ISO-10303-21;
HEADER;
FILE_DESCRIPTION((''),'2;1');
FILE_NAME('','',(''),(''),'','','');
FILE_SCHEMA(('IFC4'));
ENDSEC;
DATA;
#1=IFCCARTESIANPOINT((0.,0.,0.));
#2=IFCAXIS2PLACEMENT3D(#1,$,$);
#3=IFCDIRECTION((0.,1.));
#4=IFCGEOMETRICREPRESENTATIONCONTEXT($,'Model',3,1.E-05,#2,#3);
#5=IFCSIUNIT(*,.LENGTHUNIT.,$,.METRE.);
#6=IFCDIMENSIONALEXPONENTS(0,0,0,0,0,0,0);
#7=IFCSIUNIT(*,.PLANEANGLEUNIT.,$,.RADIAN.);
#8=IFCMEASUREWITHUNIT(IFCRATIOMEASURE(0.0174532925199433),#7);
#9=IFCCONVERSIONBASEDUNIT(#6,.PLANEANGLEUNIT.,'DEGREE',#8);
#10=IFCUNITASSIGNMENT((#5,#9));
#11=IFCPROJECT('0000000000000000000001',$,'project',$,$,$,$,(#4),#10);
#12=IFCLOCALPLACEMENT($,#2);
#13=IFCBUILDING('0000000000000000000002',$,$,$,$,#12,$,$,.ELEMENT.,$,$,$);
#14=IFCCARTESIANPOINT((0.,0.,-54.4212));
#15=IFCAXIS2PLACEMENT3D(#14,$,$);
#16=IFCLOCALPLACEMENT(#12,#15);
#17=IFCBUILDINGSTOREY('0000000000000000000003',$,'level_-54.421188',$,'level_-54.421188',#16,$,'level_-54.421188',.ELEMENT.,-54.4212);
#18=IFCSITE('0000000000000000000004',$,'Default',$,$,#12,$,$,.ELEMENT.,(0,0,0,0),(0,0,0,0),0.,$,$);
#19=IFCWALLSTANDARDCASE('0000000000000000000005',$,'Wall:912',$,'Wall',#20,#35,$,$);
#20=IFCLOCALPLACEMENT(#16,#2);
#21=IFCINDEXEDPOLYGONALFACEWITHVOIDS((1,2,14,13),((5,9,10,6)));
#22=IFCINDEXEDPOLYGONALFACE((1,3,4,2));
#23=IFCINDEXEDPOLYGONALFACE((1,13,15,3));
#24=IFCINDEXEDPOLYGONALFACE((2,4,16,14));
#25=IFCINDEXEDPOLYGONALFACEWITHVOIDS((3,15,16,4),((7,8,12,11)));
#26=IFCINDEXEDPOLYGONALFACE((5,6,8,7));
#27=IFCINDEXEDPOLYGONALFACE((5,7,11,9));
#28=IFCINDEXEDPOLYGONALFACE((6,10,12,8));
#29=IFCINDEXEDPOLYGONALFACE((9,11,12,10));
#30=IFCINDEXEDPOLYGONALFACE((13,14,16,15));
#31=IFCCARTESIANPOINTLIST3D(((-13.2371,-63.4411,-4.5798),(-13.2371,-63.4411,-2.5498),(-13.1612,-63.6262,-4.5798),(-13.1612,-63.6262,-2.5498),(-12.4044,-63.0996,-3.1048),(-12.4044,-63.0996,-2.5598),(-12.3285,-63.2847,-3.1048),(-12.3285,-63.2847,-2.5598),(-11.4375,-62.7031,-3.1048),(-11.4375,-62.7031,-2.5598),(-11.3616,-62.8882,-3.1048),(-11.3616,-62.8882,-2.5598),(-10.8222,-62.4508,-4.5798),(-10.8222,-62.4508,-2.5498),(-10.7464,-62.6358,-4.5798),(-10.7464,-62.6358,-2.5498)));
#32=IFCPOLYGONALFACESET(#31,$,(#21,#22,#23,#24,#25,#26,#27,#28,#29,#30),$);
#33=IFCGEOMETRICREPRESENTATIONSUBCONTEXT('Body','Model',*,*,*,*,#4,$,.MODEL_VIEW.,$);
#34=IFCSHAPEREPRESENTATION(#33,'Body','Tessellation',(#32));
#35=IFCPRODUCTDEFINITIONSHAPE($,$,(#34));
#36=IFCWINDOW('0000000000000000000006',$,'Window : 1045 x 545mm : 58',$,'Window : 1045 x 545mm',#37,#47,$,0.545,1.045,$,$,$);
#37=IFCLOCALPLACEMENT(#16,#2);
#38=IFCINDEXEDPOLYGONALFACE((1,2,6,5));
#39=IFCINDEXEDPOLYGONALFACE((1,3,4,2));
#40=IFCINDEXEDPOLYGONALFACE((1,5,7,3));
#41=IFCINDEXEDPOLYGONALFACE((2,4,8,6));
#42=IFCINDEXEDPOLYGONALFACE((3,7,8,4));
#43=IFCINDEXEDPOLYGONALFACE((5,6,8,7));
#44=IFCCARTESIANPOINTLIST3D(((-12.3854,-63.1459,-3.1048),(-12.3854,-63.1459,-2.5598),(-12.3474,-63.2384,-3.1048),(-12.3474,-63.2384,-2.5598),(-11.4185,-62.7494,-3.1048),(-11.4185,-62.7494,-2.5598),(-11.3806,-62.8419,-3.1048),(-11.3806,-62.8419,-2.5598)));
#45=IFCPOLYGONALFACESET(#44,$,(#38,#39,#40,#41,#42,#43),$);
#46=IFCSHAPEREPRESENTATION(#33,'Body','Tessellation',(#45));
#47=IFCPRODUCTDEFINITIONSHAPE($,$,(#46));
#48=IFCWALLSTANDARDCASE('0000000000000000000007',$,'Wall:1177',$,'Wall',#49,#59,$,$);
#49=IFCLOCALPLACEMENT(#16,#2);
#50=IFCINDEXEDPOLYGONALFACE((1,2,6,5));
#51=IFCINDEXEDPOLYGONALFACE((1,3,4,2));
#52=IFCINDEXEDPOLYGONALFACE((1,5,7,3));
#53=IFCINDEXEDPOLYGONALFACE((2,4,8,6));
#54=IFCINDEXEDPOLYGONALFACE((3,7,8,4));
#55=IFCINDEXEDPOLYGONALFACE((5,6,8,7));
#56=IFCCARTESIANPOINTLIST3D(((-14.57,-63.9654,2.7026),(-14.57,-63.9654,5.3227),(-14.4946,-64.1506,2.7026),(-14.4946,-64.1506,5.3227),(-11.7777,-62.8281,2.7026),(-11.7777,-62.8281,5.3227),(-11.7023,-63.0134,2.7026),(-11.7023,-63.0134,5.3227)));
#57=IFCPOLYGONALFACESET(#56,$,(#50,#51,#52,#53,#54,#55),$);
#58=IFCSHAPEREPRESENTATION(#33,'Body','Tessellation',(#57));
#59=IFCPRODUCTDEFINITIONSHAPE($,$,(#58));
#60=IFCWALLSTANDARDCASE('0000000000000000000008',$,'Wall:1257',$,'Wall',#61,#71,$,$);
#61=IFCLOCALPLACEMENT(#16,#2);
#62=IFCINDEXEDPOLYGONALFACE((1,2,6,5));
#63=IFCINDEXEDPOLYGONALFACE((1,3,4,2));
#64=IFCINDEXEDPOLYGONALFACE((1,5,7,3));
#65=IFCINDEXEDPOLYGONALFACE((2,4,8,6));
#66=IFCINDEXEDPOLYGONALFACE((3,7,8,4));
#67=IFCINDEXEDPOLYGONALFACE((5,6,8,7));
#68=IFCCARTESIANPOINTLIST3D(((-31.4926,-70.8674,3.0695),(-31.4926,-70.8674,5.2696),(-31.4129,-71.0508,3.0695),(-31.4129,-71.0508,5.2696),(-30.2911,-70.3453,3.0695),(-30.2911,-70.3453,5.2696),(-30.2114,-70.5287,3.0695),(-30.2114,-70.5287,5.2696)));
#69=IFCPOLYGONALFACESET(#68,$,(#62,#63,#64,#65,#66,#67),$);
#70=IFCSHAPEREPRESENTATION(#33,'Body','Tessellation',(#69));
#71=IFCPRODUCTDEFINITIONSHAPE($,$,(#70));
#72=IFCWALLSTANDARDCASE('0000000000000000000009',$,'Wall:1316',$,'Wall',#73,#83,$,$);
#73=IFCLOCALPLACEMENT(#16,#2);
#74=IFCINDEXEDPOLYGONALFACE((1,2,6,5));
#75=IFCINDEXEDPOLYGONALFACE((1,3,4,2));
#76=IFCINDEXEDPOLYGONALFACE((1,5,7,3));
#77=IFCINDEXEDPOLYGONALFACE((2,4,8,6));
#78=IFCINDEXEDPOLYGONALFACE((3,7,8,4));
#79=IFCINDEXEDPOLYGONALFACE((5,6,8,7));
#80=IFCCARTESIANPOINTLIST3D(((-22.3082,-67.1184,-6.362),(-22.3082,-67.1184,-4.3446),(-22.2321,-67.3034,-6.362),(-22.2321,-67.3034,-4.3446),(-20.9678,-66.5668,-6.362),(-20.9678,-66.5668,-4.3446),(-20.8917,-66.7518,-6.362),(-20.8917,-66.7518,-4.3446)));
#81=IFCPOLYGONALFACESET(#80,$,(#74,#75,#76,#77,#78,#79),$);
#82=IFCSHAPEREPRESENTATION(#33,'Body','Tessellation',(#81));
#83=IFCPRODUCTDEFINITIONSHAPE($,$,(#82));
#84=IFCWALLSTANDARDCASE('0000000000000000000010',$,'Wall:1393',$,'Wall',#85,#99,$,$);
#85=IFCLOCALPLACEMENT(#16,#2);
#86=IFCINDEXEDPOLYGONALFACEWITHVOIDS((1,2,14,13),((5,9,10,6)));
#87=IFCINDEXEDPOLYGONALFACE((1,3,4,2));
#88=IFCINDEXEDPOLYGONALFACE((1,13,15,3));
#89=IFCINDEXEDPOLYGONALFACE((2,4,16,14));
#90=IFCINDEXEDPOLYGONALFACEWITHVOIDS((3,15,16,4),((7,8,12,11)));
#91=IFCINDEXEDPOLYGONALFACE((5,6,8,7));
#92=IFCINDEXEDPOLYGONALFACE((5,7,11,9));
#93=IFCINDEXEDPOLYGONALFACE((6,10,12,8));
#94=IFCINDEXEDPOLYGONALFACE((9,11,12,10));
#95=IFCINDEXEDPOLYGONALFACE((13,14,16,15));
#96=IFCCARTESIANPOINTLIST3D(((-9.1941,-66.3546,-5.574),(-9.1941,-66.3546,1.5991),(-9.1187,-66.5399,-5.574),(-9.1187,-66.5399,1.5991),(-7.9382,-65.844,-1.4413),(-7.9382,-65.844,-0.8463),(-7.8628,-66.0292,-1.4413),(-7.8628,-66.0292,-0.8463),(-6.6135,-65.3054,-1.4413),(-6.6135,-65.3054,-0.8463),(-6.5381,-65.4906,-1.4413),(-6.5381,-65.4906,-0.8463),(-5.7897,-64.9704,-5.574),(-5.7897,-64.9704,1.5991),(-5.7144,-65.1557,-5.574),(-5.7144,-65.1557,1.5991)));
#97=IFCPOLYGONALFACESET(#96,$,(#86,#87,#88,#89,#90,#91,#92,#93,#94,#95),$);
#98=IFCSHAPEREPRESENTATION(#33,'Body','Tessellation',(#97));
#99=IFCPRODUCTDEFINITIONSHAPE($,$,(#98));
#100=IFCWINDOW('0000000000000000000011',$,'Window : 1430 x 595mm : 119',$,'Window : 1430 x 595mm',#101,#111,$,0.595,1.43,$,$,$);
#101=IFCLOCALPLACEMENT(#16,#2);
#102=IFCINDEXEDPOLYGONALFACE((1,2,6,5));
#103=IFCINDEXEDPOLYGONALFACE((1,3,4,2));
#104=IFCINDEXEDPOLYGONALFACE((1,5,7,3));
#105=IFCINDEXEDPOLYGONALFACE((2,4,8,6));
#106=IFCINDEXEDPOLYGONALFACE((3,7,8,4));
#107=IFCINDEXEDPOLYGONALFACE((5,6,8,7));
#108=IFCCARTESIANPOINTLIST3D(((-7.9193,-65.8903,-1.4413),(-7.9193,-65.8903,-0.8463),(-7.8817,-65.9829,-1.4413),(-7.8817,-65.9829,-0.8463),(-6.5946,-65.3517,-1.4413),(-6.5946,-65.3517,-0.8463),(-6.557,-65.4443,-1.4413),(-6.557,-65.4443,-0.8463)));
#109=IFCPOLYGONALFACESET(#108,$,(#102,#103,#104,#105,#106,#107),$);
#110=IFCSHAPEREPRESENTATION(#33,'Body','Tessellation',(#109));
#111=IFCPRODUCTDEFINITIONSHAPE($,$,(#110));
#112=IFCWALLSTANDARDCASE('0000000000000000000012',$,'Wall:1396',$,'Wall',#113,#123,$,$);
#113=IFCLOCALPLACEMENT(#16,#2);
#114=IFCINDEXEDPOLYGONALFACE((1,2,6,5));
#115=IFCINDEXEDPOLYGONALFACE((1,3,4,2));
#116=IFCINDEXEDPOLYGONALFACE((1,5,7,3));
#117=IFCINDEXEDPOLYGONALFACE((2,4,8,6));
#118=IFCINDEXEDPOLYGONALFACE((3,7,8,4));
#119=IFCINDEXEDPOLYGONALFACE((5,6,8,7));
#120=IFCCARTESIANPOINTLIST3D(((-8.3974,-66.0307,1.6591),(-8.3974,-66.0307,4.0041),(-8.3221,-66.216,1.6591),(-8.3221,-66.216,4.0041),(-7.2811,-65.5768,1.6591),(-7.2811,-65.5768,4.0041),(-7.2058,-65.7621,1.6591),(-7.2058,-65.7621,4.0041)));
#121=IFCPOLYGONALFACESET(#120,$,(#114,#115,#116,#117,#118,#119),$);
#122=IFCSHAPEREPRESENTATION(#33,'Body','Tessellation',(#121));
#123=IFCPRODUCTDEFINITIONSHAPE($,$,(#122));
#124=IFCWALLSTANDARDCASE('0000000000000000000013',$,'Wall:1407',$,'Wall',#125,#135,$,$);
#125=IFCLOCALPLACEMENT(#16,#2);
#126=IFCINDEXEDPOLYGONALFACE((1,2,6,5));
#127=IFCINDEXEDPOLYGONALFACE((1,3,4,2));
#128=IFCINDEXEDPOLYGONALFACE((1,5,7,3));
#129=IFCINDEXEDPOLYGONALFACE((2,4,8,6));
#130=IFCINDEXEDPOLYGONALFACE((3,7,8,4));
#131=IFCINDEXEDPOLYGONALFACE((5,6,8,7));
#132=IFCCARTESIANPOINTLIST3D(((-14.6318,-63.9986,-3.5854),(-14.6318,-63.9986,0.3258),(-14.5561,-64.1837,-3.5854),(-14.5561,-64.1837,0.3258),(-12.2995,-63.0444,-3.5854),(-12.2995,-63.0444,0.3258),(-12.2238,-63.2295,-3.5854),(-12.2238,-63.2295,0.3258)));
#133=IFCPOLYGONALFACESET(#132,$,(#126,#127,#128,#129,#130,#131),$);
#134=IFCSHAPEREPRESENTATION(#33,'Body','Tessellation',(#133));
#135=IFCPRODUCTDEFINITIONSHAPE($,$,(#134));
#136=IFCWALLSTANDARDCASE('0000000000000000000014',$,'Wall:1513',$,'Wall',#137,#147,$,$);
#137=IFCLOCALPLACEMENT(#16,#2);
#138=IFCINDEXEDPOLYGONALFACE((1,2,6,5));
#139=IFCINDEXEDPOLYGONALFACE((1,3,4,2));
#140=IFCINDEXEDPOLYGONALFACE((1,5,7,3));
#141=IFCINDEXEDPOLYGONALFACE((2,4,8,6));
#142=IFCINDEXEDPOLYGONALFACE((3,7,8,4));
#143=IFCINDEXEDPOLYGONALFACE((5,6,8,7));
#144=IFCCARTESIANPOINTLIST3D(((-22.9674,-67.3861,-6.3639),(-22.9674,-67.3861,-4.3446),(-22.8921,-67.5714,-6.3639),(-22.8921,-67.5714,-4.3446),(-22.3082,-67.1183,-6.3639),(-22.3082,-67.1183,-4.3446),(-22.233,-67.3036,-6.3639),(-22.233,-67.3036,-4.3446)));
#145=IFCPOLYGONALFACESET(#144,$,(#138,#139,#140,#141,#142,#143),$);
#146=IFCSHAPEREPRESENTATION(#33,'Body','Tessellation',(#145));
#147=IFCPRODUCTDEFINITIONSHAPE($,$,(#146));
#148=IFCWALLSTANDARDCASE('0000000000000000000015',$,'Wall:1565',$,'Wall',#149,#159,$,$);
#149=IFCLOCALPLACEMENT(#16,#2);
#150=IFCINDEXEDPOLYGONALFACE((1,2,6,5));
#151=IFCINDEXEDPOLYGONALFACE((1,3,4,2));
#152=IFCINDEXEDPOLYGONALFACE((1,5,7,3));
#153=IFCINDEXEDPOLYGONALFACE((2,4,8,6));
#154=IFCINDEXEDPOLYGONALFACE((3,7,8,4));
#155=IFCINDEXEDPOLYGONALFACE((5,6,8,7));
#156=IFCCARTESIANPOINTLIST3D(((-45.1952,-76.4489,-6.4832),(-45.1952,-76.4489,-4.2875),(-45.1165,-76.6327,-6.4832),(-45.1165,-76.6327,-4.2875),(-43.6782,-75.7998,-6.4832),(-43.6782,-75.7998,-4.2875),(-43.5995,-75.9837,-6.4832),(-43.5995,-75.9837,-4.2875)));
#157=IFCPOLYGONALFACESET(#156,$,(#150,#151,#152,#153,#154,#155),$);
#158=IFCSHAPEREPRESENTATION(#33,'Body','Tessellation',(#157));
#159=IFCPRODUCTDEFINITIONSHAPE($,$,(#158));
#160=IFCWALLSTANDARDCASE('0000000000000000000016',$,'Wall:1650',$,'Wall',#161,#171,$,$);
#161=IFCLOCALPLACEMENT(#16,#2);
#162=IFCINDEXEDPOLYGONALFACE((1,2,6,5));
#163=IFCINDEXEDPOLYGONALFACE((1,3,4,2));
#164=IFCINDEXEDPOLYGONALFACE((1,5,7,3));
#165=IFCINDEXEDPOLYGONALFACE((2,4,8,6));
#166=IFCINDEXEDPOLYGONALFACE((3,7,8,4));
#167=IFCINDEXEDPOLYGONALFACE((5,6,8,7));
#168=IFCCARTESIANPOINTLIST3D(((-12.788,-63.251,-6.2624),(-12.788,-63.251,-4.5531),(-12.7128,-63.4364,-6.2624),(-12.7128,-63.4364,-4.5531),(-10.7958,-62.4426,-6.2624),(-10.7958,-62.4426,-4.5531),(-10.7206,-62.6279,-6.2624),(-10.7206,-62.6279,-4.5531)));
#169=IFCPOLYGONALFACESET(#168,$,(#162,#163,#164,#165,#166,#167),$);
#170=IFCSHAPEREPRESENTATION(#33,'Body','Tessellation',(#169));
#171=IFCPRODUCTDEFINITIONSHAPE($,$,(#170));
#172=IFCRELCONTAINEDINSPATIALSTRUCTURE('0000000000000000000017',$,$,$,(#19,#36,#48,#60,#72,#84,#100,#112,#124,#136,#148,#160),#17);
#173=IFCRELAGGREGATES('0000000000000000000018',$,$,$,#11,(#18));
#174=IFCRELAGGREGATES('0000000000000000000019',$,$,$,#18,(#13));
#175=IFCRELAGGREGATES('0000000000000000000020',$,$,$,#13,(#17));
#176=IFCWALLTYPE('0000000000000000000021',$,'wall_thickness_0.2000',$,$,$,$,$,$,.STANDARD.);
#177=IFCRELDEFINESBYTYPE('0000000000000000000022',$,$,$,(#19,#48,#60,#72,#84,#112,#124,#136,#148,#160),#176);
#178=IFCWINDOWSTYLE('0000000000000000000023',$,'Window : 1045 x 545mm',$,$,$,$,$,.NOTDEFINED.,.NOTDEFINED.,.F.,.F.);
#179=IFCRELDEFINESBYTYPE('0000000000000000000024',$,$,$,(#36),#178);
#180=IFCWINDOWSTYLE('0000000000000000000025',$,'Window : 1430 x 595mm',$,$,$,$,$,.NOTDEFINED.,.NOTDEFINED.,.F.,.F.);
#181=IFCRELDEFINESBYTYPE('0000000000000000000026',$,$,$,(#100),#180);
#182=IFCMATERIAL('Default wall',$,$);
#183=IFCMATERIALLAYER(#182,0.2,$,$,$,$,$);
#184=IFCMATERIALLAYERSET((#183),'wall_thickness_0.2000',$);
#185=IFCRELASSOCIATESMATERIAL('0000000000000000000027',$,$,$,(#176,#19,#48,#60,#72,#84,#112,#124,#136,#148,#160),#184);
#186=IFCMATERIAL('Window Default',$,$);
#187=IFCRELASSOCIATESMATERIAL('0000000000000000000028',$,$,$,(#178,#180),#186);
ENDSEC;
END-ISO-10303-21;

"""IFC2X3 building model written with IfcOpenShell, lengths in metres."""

from ifc_helpers import new_model, entity, si_unit, converted_unit, direction, frame, frame_2d, origin, origin_2d_with_axis, place, context, subcontext, project, spatial, polyline, rectangle, outline, extrude, source, transform, mapped, material, layer, layer_set, layer_usage, type_object, type_shapes, element, fill, save


model = new_model("IFC2X3")

# Units and contexts
model_context = context("Model", 3, precision=1e-05, world=origin(), true_north=direction((0.0, 1.0)))
body_context = subcontext(model_context, "Body", "Model", "MODEL_VIEW")
ifc_project = project(units=[si_unit("LENGTHUNIT", "METRE"), converted_unit("PLANEANGLEUNIT", "DEGREE", entity("IfcRatioMeasure", 0.0174532925199433), si_unit("PLANEANGLEUNIT", "RADIAN"), dimensions=[0, 0, 0, 0, 0, 0, 0])], contexts=[model_context])

# Site, building, storey
placement_1 = place(None, origin())
site = spatial("IfcSite", under=ifc_project, at=placement_1, Name="Default", CompositionType="ELEMENT", RefLatitude=(0, 0, 0, 0), RefLongitude=(0, 0, 0, 0), RefElevation=0.0)
building = spatial("IfcBuilding", under=site, at=placement_1, CompositionType="ELEMENT")
storey_placement = place(placement_1, frame((0.0, 0.0, -54.4212)))
storey = spatial("IfcBuildingStorey", under=building, at=storey_placement, Name="level_-54.421188", ObjectType="level_-54.421188", LongName="level_-54.421188", CompositionType="ELEMENT", Elevation=-54.4212)

# Shared definitions
ifc_material_1 = material(Name="Default wall")
ifc_layer = layer(ifc_material_1, 0.2)
ifc_layer_set = layer_set([ifc_layer], Name="wall_thickness_0.2000")
ifc_layer_usage = layer_usage(ifc_layer_set, "AXIS2", "POSITIVE", -0.1)
wall_type = type_object("IfcWallType", Name="wall_thickness_0.2000", PredefinedType="STANDARD", material=ifc_layer_set)

# Wall, opening, window
placement_2 = place(placement_1, frame((0.0, 0.0, -59.001)))
wall_1_placement = place(placement_2, frame((-13.1991, -63.5337, 0.0), z_axis=(0.0, 0.0, 1.0), x_axis=(0.925216, 0.379441, 0.0)))
wall_1 = element("IfcWallStandardCase", 1, at=wall_1_placement, inside=storey, type_object=wall_type, material=ifc_layer_usage, Name="Wall:912", ObjectType="Wall", context=body_context, shape_type="SweptSolid", body=[
    extrude(outline(polyline([(2.61, -0.1), (2.61, 0.1), (0.0, 0.1), (0.0, -0.1), (2.61, -0.1)])), origin(), (0.0, 0.0, 1.0), 2.03),
])
opening_1_placement = place(wall_1_placement, frame((0.9, -0.1, 1.475)))
opening_1 = element("IfcOpeningElement", 2, at=opening_1_placement, cuts=wall_1, ObjectType="Opening", context=body_context, shape_type="SweptSolid", body=[
    extrude(rectangle(XDim=1.045, YDim=0.545, at=frame_2d((0.2725, 0.5225), x_axis=(0.0, 1.0))), frame((0.0, 0.0, 0.0), z_axis=(0.0, 1.0, 0.0), x_axis=(0.0, 0.0, 1.0)), (0.0, 0.0, 1.0), 0.2),
])
ifc_material_2 = material(Name="Window Default")
window_style_1 = type_object("IfcWindowStyle", Name="Window : 1045 x 545mm", ConstructionType="NOTDEFINED", OperationType="NOTDEFINED", ParameterTakesPrecedence=False, Sizeable=False, material=ifc_material_2)
shared_shape_1 = source(origin(), body_context, "Body", "SweptSolid", [
    extrude(rectangle(XDim=0.1, YDim=1.045, at=origin_2d_with_axis()), frame((0.5225, 0.1, 0.0), z_axis=(0.0, 0.0, 1.0), x_axis=(0.0, 1.0, 0.0)), (0.0, 0.0, 1.0), 0.545),
])
type_shapes(window_style_1, [shared_shape_1])
window_1_placement = place(opening_1_placement, origin())
window_1 = element("IfcWindow", 3, at=window_1_placement, inside=storey, type_object=window_style_1, Name="Window : 1045 x 545mm : 58", ObjectType="Window : 1045 x 545mm", OverallHeight=0.545, OverallWidth=1.045, context=body_context, shape_type="MappedRepresentation", body=[
    mapped(shared_shape_1, transform((0.0, 0.0, 0.0), scale=1.0)),
])
fill(opening_1, window_1)

# Walls
placement_3 = place(placement_1, frame((0.0, 0.0, -51.7186)))
wall_2_placement = place(placement_3, frame((-11.74, -62.9207, 0.0), z_axis=(0.0, 0.0, 1.0), x_axis=(-0.926134, -0.377196, 0.0)))
element("IfcWallStandardCase", 4, at=wall_2_placement, inside=storey, type_object=wall_type, material=ifc_layer_usage, Name="Wall:1177", ObjectType="Wall", context=body_context, shape_type="SweptSolid", body=[
    extrude(outline(polyline([(3.015, -0.1), (3.015, 0.1), (0.0, 0.1), (0.0, -0.1), (3.015, -0.1)])), origin(), (0.0, 0.0, 1.0), 2.6201),
])
placement_4 = place(placement_1, frame((0.0, 0.0, -51.3517)))
wall_3_placement = place(placement_4, frame((-30.2513, -70.437, 0.0), z_axis=(0.0, 0.0, 1.0), x_axis=(-0.917161, -0.398516, 0.0)))
element("IfcWallStandardCase", 5, at=wall_3_placement, inside=storey, type_object=wall_type, material=ifc_layer_usage, Name="Wall:1257", ObjectType="Wall", context=body_context, shape_type="SweptSolid", body=[
    extrude(outline(polyline([(1.31, -0.1), (1.31, 0.1), (0.0, 0.1), (0.0, -0.1), (1.31, -0.1)])), origin(), (0.0, 0.0, 1.0), 2.2001),
])
placement_5 = place(placement_1, frame((0.0, 0.0, -60.7832)))
wall_4_placement = place(placement_5, frame((-20.9298, -66.6593, 0.0), z_axis=(0.0, 0.0, 1.0), x_axis=(-0.924764, -0.380541, 0.0)))
element("IfcWallStandardCase", 6, at=wall_4_placement, inside=storey, type_object=wall_type, material=ifc_layer_usage, Name="Wall:1316", ObjectType="Wall", context=body_context, shape_type="SweptSolid", body=[
    extrude(outline(polyline([(1.4494, -0.1), (1.4494, 0.1), (0.0, 0.1), (0.0, -0.1), (1.4494, -0.1)])), origin(), (0.0, 0.0, 1.0), 2.0174),
])

# Wall, opening, window
placement_6 = place(placement_1, frame((0.0, 0.0, -59.9952)))
wall_5_placement = place(placement_6, frame((-5.752, -65.0631, 0.0), z_axis=(0.0, 0.0, 1.0), x_axis=(-0.926359, -0.376643, 0.0)))
wall_5 = element("IfcWallStandardCase", 7, at=wall_5_placement, inside=storey, type_object=wall_type, material=ifc_layer_usage, Name="Wall:1393", ObjectType="Wall", context=body_context, shape_type="SweptSolid", body=[
    extrude(outline(polyline([(3.675, -0.1), (3.675, 0.1), (0.0, 0.1), (0.0, -0.1), (3.675, -0.1)])), origin(), (0.0, 0.0, 1.0), 7.1731),
])
opening_2_placement = place(wall_5_placement, frame((0.8892, -0.1, 4.1327)))
opening_2 = element("IfcOpeningElement", 8, at=opening_2_placement, cuts=wall_5, ObjectType="Opening", context=body_context, shape_type="SweptSolid", body=[
    extrude(rectangle(XDim=1.43, YDim=0.595, at=frame_2d((0.2975, 0.715), x_axis=(0.0, 1.0))), frame((0.0, 0.0, 0.0), z_axis=(0.0, 1.0, 0.0), x_axis=(0.0, 0.0, 1.0)), (0.0, 0.0, 1.0), 0.2),
])
window_style_2 = type_object("IfcWindowStyle", Name="Window : 1430 x 595mm", ConstructionType="NOTDEFINED", OperationType="NOTDEFINED", ParameterTakesPrecedence=False, Sizeable=False, material=ifc_material_2)
shared_shape_2 = source(origin(), body_context, "Body", "SweptSolid", [
    extrude(rectangle(XDim=0.1, YDim=1.43, at=origin_2d_with_axis()), frame((0.715, 0.1, 0.0), z_axis=(0.0, 0.0, 1.0), x_axis=(0.0, 1.0, 0.0)), (0.0, 0.0, 1.0), 0.595),
])
type_shapes(window_style_2, [shared_shape_2])
window_2_placement = place(opening_2_placement, origin())
window_2 = element("IfcWindow", 9, at=window_2_placement, inside=storey, type_object=window_style_2, Name="Window : 1430 x 595mm : 119", ObjectType="Window : 1430 x 595mm", OverallHeight=0.595, OverallWidth=1.43, context=body_context, shape_type="MappedRepresentation", body=[
    mapped(shared_shape_2, transform((0.0, 0.0, 0.0), scale=1.0)),
])
fill(opening_2, window_2)

# Walls
placement_7 = place(placement_1, frame((0.0, 0.0, -52.7621)))
wall_6_placement = place(placement_7, frame((-7.2435, -65.6695, 0.0), z_axis=(0.0, 0.0, 1.0), x_axis=(-0.926358, -0.376645, 0.0)))
element("IfcWallStandardCase", 10, at=wall_6_placement, inside=storey, type_object=wall_type, material=ifc_layer_usage, Name="Wall:1396", ObjectType="Wall", context=body_context, shape_type="SweptSolid", body=[
    extrude(outline(polyline([(1.205, -0.1), (1.205, 0.1), (0.0, 0.1), (0.0, -0.1), (1.205, -0.1)])), origin(), (0.0, 0.0, 1.0), 2.345),
])
placement_8 = place(placement_1, frame((0.0, 0.0, -58.0066)))
wall_7_placement = place(placement_8, frame((-12.2616, -63.1369, 0.0), z_axis=(0.0, 0.0, 1.0), x_axis=(-0.925539, -0.378653, 0.0)))
element("IfcWallStandardCase", 11, at=wall_7_placement, inside=storey, type_object=wall_type, material=ifc_layer_usage, Name="Wall:1407", ObjectType="Wall", context=body_context, shape_type="SweptSolid", body=[
    extrude(outline(polyline([(2.52, -0.1), (2.52, 0.1), (0.0, 0.1), (0.0, -0.1), (2.52, -0.1)])), origin(), (0.0, 0.0, 1.0), 3.9112),
])
placement_9 = place(placement_1, frame((0.0, 0.0, -60.7851)))
wall_8_placement = place(placement_9, frame((-22.2706, -67.2109, 0.0), z_axis=(0.0, 0.0, 1.0), x_axis=(-0.926454, -0.376409, 0.0)))
element("IfcWallStandardCase", 12, at=wall_8_placement, inside=storey, type_object=wall_type, material=ifc_layer_usage, Name="Wall:1513", ObjectType="Wall", context=body_context, shape_type="SweptSolid", body=[
    extrude(outline(polyline([(0.7115, -0.1), (0.7115, 0.1), (0.0, 0.1), (0.0, -0.1), (0.7115, -0.1)])), origin(), (0.0, 0.0, 1.0), 2.0194),
])
placement_10 = place(placement_1, frame((0.0, 0.0, -60.9044)))
wall_9_placement = place(placement_10, frame((-43.6388, -75.8918, 0.0), z_axis=(0.0, 0.0, 1.0), x_axis=(-0.919391, -0.393344, 0.0)))
element("IfcWallStandardCase", 13, at=wall_9_placement, inside=storey, type_object=wall_type, material=ifc_layer_usage, Name="Wall:1565", ObjectType="Wall", context=body_context, shape_type="SweptSolid", body=[
    extrude(outline(polyline([(1.65, -0.1), (1.65, 0.1), (0.0, 0.1), (0.0, -0.1), (1.65, -0.1)])), origin(), (0.0, 0.0, 1.0), 2.1958),
])
placement_11 = place(placement_1, frame((0.0, 0.0, -60.6836)))
wall_10_placement = place(placement_11, frame((-12.7504, -63.3437, 0.0), z_axis=(0.0, 0.0, 1.0), x_axis=(0.926606, 0.376033, 0.0)))
element("IfcWallStandardCase", 14, at=wall_10_placement, inside=storey, type_object=wall_type, material=ifc_layer_usage, Name="Wall:1650", ObjectType="Wall", context=body_context, shape_type="SweptSolid", body=[
    extrude(outline(polyline([(2.15, -0.1), (2.15, 0.1), (0.0, 0.1), (0.0, -0.1), (2.15, -0.1)])), origin(), (0.0, 0.0, 1.0), 1.7092),
])

save(model, "model.ifc")
